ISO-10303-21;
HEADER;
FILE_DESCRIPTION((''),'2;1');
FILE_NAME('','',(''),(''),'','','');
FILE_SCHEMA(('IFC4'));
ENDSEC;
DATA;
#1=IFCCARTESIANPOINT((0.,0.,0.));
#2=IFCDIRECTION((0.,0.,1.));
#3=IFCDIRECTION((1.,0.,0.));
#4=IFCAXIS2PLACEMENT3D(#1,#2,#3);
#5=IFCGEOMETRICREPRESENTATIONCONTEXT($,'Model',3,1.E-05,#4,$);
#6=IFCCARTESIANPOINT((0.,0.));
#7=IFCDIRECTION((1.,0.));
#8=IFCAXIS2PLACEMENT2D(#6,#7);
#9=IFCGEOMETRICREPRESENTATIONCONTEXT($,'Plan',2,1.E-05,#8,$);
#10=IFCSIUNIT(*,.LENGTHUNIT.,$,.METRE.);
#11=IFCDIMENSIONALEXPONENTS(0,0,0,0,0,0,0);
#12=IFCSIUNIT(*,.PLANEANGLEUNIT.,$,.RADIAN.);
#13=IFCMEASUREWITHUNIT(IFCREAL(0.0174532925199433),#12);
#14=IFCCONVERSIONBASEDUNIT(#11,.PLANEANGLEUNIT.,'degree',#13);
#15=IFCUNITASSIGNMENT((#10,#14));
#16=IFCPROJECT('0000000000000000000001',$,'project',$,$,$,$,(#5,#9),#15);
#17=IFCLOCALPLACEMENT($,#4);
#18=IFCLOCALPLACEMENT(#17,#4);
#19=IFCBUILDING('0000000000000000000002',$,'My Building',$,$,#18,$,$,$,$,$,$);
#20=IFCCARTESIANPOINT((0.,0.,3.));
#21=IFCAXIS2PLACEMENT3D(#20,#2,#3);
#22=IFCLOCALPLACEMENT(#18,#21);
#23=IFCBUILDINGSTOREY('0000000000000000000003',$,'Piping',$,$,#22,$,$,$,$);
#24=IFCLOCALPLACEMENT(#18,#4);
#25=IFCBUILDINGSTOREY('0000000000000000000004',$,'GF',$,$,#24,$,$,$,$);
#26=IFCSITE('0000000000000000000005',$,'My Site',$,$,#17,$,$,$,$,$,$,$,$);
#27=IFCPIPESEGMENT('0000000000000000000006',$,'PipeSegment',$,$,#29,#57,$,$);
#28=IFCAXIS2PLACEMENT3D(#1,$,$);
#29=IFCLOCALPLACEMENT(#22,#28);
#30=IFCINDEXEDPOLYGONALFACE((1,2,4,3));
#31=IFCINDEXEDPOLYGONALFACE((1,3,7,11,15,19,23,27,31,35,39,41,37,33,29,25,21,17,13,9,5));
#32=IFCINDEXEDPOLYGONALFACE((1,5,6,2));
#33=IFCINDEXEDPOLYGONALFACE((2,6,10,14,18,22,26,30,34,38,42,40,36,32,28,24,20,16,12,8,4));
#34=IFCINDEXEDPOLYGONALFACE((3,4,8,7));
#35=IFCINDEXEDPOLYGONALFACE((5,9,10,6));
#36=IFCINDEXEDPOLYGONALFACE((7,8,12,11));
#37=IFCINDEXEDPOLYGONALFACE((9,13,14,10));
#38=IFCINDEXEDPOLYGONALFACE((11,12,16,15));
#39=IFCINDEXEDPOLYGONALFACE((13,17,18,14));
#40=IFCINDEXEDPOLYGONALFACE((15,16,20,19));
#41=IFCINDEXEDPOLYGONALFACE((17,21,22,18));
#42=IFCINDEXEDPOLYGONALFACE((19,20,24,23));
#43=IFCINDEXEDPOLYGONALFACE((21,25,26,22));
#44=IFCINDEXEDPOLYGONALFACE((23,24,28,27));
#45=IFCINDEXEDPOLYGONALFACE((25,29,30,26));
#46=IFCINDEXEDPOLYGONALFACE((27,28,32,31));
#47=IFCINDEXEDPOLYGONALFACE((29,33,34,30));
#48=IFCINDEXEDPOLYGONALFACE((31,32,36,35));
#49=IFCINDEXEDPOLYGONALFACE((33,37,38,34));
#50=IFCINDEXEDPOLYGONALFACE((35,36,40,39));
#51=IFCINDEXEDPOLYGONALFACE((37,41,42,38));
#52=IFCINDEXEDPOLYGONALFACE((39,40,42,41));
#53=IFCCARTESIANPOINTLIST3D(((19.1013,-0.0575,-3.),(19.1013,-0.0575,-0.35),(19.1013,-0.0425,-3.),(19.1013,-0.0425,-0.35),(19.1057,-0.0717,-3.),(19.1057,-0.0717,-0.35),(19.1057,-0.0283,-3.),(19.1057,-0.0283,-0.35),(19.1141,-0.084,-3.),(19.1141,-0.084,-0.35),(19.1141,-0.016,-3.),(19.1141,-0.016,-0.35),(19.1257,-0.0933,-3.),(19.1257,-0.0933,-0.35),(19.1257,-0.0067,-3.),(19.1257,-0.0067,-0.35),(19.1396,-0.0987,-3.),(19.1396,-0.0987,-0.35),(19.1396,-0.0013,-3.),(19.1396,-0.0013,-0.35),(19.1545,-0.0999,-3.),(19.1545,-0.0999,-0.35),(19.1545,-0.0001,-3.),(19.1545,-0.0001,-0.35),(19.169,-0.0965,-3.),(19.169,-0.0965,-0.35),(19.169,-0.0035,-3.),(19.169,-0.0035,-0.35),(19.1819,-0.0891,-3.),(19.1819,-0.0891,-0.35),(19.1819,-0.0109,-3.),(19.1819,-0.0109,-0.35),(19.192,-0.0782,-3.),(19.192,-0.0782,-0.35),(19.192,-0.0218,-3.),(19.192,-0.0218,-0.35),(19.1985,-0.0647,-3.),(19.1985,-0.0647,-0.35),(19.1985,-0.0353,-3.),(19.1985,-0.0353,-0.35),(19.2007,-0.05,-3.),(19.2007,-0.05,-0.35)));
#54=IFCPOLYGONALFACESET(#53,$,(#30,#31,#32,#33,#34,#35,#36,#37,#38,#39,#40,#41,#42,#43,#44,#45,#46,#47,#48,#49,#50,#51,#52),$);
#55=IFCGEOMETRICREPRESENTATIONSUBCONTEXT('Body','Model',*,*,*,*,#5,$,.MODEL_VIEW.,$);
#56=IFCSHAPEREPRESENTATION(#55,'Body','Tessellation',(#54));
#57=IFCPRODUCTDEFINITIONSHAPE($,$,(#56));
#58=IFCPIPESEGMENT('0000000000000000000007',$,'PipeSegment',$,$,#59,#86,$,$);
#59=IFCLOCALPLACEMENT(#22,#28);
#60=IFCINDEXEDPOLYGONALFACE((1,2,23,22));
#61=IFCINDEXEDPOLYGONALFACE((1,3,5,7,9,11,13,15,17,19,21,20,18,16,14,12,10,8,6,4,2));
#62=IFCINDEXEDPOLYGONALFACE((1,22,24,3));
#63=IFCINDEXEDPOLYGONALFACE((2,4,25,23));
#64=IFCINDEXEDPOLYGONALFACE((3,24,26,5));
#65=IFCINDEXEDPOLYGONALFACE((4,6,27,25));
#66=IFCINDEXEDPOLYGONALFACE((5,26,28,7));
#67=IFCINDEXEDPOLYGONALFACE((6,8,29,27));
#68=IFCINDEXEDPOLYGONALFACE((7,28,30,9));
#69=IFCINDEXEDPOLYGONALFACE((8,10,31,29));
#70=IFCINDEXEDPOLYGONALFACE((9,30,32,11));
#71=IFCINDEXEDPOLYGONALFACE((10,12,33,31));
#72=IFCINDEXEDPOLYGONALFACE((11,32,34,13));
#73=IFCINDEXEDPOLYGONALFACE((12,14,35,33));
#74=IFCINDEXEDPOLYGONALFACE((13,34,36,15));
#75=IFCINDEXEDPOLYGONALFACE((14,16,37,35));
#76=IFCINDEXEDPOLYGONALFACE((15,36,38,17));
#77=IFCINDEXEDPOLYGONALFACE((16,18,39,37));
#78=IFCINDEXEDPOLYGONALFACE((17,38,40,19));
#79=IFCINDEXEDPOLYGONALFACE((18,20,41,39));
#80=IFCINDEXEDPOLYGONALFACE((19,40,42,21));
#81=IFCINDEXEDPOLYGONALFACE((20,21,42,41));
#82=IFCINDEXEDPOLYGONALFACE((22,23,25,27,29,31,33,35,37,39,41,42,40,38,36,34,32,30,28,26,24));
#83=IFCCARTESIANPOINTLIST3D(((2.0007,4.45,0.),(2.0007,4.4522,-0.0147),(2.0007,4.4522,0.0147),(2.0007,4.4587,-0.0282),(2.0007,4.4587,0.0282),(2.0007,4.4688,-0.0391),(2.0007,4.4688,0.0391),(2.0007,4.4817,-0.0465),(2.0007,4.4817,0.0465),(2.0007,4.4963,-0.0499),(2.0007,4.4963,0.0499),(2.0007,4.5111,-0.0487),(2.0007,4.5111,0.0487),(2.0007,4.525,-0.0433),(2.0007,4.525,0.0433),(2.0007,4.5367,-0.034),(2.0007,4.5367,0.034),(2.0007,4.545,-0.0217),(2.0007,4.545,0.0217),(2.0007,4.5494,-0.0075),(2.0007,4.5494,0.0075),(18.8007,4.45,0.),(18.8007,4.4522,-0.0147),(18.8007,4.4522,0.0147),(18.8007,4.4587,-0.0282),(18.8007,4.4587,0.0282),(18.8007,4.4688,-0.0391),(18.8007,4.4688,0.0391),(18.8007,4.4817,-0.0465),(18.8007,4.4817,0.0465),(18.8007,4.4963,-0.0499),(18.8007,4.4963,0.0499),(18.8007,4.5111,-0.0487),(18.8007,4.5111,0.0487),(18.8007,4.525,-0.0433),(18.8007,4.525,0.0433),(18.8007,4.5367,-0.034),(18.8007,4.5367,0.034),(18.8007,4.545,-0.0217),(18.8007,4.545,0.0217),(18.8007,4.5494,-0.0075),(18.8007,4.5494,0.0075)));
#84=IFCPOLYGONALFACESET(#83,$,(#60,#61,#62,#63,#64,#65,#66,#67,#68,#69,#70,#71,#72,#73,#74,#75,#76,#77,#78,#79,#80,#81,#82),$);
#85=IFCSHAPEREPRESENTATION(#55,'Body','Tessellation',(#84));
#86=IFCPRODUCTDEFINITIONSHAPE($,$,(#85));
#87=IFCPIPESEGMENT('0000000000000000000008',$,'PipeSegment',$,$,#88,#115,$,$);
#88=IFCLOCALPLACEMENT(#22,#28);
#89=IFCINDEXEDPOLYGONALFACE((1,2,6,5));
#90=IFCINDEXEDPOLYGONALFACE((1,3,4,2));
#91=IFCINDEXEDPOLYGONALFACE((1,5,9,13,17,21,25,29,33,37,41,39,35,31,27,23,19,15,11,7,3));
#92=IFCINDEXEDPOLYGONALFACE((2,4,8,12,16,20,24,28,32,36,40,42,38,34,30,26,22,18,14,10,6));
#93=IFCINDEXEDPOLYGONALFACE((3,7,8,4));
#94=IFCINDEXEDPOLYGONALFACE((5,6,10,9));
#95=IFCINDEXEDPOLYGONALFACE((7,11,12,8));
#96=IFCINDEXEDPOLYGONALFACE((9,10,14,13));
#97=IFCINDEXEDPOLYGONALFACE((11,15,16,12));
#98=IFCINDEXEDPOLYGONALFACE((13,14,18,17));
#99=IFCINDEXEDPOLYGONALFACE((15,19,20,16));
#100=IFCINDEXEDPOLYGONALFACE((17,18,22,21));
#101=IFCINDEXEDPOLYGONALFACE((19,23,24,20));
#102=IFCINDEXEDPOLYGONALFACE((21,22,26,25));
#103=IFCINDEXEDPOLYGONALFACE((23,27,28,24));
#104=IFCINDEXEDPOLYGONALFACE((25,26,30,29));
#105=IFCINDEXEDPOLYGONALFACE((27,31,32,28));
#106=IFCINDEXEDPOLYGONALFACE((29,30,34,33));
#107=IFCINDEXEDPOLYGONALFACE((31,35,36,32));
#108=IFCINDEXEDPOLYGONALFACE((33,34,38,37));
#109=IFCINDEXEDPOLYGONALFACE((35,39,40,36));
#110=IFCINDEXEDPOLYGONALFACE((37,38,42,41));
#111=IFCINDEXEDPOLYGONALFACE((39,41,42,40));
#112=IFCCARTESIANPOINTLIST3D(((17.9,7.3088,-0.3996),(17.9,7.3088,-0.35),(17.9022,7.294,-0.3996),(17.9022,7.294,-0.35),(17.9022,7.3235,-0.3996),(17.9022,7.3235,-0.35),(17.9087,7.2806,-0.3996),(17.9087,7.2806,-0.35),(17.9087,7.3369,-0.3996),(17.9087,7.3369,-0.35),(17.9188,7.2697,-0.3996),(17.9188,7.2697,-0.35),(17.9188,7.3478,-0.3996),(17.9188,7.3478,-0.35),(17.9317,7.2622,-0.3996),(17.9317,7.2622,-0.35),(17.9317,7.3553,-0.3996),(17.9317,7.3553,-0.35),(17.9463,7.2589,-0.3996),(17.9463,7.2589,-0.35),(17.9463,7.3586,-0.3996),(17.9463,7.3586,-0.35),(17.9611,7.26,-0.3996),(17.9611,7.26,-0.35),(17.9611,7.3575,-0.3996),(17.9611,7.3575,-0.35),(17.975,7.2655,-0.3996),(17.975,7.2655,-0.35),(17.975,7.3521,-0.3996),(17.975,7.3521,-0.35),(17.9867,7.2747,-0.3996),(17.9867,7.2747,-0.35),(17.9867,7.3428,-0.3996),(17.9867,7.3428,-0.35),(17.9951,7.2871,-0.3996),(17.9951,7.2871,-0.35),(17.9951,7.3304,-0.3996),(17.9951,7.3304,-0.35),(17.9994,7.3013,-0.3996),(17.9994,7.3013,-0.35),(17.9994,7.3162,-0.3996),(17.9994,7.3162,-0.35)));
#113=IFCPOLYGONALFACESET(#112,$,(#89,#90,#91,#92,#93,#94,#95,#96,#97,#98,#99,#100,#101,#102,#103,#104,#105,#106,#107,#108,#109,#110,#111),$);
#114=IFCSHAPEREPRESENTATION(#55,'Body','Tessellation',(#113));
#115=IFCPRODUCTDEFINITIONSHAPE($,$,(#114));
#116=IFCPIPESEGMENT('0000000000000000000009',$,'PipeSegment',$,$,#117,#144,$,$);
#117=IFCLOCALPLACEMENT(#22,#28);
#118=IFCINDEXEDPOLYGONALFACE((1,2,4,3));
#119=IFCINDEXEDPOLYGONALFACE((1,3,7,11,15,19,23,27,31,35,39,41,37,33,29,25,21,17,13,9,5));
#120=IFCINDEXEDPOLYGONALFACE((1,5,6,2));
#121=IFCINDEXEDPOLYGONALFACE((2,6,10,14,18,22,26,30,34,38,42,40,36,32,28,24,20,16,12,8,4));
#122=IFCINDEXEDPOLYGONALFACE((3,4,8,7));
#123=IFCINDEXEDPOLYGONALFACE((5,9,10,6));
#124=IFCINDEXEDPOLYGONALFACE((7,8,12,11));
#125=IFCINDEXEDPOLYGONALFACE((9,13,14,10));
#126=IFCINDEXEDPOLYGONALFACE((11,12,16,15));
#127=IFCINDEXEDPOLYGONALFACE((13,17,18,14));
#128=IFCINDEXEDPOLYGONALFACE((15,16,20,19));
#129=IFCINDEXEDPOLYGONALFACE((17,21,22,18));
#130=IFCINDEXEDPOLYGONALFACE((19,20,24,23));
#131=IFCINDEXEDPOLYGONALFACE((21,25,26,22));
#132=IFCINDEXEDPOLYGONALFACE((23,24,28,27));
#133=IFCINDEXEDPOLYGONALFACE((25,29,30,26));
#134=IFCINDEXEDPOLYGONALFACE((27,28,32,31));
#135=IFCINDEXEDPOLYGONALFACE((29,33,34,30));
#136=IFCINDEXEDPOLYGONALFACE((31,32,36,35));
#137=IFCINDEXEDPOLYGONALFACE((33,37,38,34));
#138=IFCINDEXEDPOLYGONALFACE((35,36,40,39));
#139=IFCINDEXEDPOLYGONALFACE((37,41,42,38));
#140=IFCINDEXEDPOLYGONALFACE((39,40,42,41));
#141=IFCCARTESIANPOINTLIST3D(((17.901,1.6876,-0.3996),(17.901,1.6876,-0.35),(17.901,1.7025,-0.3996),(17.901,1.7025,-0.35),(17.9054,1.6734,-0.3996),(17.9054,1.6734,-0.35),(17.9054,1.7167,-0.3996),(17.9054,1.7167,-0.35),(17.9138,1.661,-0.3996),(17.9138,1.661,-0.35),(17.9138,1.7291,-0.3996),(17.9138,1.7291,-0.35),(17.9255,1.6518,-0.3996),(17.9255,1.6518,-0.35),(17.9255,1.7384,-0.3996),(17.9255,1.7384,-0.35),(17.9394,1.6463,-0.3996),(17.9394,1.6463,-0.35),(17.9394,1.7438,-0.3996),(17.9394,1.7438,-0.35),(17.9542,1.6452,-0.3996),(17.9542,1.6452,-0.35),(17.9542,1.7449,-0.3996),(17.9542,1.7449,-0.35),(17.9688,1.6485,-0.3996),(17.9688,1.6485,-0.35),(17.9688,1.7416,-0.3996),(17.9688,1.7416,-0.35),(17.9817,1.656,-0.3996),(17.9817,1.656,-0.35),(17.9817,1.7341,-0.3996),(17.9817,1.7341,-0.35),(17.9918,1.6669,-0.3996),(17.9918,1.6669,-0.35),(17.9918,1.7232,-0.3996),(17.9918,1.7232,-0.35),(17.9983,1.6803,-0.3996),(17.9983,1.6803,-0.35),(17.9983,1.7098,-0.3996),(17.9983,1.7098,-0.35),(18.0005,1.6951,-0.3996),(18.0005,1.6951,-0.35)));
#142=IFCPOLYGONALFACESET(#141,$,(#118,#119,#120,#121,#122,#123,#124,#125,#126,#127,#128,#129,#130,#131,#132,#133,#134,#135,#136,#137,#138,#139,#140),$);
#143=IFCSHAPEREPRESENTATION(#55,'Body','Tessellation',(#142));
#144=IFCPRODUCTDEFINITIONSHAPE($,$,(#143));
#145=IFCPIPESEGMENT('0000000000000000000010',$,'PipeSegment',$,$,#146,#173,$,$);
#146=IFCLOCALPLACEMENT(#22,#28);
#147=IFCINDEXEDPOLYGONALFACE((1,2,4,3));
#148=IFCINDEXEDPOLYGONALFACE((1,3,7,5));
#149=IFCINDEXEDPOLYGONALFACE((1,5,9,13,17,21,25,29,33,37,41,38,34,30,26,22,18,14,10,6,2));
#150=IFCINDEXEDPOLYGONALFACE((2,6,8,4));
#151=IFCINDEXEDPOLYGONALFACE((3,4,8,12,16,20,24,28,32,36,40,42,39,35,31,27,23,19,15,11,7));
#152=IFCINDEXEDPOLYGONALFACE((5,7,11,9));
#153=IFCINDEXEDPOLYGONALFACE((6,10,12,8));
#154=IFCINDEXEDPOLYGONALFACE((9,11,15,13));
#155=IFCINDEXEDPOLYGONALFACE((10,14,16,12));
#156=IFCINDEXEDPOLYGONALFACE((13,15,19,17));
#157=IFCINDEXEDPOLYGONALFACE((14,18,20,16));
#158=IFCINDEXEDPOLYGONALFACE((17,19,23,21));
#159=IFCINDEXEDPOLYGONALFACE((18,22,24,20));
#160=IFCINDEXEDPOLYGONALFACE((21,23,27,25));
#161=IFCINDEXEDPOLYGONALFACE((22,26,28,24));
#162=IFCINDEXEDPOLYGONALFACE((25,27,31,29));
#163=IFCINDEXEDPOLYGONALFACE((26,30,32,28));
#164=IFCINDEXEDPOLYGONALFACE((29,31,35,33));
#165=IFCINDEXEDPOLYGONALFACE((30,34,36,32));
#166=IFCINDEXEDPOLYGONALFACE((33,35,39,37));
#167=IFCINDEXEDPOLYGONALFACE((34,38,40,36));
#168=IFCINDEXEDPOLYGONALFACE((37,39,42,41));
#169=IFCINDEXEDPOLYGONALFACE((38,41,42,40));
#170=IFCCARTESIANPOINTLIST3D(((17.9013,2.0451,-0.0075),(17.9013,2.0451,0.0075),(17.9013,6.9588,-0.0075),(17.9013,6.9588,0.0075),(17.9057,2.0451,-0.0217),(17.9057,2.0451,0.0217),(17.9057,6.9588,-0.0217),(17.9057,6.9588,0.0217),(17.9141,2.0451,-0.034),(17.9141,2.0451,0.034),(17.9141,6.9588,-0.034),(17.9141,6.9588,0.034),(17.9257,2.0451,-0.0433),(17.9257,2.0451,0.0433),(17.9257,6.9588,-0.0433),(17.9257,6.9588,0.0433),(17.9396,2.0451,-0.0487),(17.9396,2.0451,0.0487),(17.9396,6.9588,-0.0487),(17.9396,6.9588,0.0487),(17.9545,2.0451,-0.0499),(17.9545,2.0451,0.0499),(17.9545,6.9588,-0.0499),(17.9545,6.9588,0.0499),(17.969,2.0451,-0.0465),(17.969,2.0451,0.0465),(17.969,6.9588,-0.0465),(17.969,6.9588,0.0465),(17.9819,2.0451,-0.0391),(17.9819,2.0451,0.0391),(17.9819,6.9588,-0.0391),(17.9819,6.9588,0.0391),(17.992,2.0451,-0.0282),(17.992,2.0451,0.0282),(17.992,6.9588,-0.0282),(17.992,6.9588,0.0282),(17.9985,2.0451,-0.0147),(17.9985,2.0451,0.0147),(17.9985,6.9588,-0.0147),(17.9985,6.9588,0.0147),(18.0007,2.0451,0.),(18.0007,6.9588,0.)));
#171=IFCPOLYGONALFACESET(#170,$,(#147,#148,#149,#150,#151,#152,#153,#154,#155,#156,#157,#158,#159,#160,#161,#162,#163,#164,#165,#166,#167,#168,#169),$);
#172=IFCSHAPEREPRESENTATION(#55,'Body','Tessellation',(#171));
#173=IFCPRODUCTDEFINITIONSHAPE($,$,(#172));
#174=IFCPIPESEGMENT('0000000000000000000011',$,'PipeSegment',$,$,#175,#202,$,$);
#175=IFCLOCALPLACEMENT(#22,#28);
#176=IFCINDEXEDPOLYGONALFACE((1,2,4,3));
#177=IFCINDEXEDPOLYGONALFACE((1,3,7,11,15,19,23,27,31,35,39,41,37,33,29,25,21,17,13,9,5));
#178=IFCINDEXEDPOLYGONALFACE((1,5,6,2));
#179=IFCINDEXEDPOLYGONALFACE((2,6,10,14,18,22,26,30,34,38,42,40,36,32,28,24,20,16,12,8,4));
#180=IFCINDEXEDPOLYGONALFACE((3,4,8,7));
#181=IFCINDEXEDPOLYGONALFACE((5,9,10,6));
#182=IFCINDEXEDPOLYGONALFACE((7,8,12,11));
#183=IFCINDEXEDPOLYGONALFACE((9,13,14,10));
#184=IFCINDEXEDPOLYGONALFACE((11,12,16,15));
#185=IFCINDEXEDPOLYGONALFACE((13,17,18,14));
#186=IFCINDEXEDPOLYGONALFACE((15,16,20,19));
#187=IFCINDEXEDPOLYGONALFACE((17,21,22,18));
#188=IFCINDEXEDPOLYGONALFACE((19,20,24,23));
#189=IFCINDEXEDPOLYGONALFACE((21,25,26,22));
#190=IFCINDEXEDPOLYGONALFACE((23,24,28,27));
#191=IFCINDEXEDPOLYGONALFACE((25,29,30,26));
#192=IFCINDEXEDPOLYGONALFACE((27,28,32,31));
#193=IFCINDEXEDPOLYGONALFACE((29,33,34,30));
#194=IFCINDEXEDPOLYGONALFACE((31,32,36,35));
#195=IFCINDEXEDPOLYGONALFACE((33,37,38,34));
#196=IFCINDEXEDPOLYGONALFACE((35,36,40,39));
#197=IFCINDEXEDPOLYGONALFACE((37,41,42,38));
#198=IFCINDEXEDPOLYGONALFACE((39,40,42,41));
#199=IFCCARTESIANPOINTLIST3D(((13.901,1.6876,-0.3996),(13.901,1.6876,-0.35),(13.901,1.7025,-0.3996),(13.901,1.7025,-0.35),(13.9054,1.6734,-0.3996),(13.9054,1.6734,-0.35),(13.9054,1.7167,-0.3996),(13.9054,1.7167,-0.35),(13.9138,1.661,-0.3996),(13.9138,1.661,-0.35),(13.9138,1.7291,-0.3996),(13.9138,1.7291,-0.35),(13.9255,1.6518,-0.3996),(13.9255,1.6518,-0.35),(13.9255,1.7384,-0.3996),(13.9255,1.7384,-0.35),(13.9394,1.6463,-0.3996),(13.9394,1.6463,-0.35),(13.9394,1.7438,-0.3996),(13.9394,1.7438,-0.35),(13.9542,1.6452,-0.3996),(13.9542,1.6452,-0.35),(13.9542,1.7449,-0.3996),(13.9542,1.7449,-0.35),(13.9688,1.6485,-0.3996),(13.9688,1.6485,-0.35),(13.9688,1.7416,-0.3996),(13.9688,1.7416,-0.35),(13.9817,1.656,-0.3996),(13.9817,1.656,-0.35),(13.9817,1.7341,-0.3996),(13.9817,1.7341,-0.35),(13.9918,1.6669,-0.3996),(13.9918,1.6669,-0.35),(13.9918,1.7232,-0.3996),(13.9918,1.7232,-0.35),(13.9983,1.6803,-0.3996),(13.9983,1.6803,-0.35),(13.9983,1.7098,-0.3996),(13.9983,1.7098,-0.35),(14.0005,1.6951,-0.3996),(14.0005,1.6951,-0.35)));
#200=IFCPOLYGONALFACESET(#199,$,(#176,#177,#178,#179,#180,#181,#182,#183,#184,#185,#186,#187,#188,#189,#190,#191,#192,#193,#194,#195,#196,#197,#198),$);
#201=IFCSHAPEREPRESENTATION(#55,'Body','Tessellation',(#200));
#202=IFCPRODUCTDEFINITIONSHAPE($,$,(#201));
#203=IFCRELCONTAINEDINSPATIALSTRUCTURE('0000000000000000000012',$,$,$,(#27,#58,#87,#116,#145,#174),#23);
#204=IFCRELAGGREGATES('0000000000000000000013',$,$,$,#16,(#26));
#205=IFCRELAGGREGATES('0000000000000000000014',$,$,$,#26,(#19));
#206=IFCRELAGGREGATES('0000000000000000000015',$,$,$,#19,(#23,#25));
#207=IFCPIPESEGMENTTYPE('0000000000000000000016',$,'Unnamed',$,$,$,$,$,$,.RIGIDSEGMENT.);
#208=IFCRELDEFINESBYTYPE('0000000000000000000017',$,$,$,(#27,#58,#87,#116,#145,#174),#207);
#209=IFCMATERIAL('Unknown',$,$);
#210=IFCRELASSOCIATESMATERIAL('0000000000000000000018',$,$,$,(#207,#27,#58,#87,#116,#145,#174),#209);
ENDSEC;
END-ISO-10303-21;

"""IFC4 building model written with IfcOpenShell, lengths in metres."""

from ifc_helpers import new_model, entity, si_unit, converted_unit, frame, origin_with_axes, origin_2d_with_axis, place, context, subcontext, project, spatial, circle, extrude, material, material_profile, profile_set, profile_usage, type_object, element, save


model = new_model("IFC4")

# Units and contexts
model_context = context("Model", 3, precision=1e-05, world=origin_with_axes())
plan_context = context("Plan", 2, precision=1e-05, world=origin_2d_with_axis())
body_context_1 = subcontext(model_context, "Body", "Model", "MODEL_VIEW")
ifc_project = project(units=[si_unit("LENGTHUNIT", "METRE"), converted_unit("PLANEANGLEUNIT", "degree", entity("IfcReal", 0.0174532925199433), si_unit("PLANEANGLEUNIT", "RADIAN"), dimensions=[0, 0, 0, 0, 0, 0, 0])], contexts=[model_context, plan_context])

# Site, building, storey
site_placement = place(None, origin_with_axes())
site = spatial("IfcSite", under=ifc_project, at=site_placement, Name="My Site")
building_placement = place(site_placement, origin_with_axes())
building = spatial("IfcBuilding", under=site, at=building_placement, Name="My Building")
storey_1_placement = place(building_placement, frame((0.0, 0.0, 3.0), z_axis=(0.0, 0.0, 1.0), x_axis=(1.0, 0.0, 0.0)))
storey_1 = spatial("IfcBuildingStorey", under=building, at=storey_1_placement, Name="Piping")

# Shared definitions
ifc_material = material(Name="Unknown")

# Shared definitions
storey_2_placement = place(building_placement, origin_with_axes())
storey_2 = spatial("IfcBuildingStorey", under=building, at=storey_2_placement, Name="GF")

# Pipe segments
ifc_material_profile = material_profile(ifc_material, circle(Radius=0.05))
ifc_profile_set = profile_set([ifc_material_profile])
ifc_profile_usage_1 = profile_usage(ifc_profile_set, cardinal=5)
pipe_segment_type = type_object("IfcPipeSegmentType", Name="Unnamed", PredefinedType="RIGIDSEGMENT", material=ifc_profile_set)
pipe_segment_1_placement = place(storey_1_placement, frame((19.1507, -0.05, -3.0), z_axis=(0.0, 0.0, 1.0), x_axis=(1.0, 0.0, 0.0)))
element("IfcPipeSegment", 1, at=pipe_segment_1_placement, inside=storey_1, type_object=pipe_segment_type, material=ifc_profile_usage_1, Name="PipeSegment", context=body_context_1, shape_type="SweptSolid", body=[
    extrude(circle(Radius=0.05), origin_with_axes(), (0.0, 0.0, 1.0), 2.65),
])
ifc_profile_usage_2 = profile_usage(ifc_profile_set, cardinal=5)
pipe_segment_2_placement = place(storey_1_placement, frame((18.8007, 4.5, 0.0), z_axis=(-1.0, 0.0, 0.0), x_axis=(0.0, -1.0, 0.0)))
element("IfcPipeSegment", 2, at=pipe_segment_2_placement, inside=storey_1, type_object=pipe_segment_type, material=ifc_profile_usage_2, Name="PipeSegment", context=body_context_1, shape_type="SweptSolid", body=[
    extrude(circle(Radius=0.05), origin_with_axes(), (0.0, 0.0, 1.0), 16.8),
])
ifc_profile_usage_3 = profile_usage(ifc_profile_set, cardinal=5)
pipe_segment_3_placement = place(storey_1_placement, frame((17.95, 7.3088, -0.35), z_axis=(0.0, 0.0, -1.0), x_axis=(-1.0, 0.0, 0.0)))
element("IfcPipeSegment", 3, at=pipe_segment_3_placement, inside=storey_1, type_object=pipe_segment_type, material=ifc_profile_usage_3, Name="PipeSegment", context=body_context_1, shape_type="SweptSolid", body=[
    extrude(circle(Radius=0.05), origin_with_axes(), (0.0, 0.0, 1.0), 0.0496),
])
ifc_profile_usage_4 = profile_usage(ifc_profile_set, cardinal=5)
pipe_segment_4_placement = place(storey_1_placement, frame((17.9505, 1.6951, -0.35), z_axis=(0.0, 0.0, -1.0), x_axis=(1.0, 0.0, 0.0)))
element("IfcPipeSegment", 4, at=pipe_segment_4_placement, inside=storey_1, type_object=pipe_segment_type, material=ifc_profile_usage_4, Name="PipeSegment", context=body_context_1, shape_type="SweptSolid", body=[
    extrude(circle(Radius=0.05), origin_with_axes(), (0.0, 0.0, 1.0), 0.0496),
])
ifc_profile_usage_5 = profile_usage(ifc_profile_set, cardinal=5)
pipe_segment_5_placement = place(storey_1_placement, frame((17.9507, 6.9588, 0.0), z_axis=(0.0, -1.0, 0.0), x_axis=(1.0, 0.0, 0.0)))
element("IfcPipeSegment", 5, at=pipe_segment_5_placement, inside=storey_1, type_object=pipe_segment_type, material=ifc_profile_usage_5, Name="PipeSegment", context=body_context_1, shape_type="SweptSolid", body=[
    extrude(circle(Radius=0.05), origin_with_axes(), (0.0, 0.0, 1.0), 4.9137),
])
ifc_profile_usage_6 = profile_usage(ifc_profile_set, cardinal=5)
pipe_segment_6_placement = place(storey_1_placement, frame((13.9505, 1.6951, -0.35), z_axis=(0.0, 0.0, -1.0), x_axis=(1.0, 0.0, 0.0)))
element("IfcPipeSegment", 6, at=pipe_segment_6_placement, inside=storey_1, type_object=pipe_segment_type, material=ifc_profile_usage_6, Name="PipeSegment", context=body_context_1, shape_type="SweptSolid", body=[
    extrude(circle(Radius=0.05), origin_with_axes(), (0.0, 0.0, 1.0), 0.0496),
])

save(model, "model.ifc")
